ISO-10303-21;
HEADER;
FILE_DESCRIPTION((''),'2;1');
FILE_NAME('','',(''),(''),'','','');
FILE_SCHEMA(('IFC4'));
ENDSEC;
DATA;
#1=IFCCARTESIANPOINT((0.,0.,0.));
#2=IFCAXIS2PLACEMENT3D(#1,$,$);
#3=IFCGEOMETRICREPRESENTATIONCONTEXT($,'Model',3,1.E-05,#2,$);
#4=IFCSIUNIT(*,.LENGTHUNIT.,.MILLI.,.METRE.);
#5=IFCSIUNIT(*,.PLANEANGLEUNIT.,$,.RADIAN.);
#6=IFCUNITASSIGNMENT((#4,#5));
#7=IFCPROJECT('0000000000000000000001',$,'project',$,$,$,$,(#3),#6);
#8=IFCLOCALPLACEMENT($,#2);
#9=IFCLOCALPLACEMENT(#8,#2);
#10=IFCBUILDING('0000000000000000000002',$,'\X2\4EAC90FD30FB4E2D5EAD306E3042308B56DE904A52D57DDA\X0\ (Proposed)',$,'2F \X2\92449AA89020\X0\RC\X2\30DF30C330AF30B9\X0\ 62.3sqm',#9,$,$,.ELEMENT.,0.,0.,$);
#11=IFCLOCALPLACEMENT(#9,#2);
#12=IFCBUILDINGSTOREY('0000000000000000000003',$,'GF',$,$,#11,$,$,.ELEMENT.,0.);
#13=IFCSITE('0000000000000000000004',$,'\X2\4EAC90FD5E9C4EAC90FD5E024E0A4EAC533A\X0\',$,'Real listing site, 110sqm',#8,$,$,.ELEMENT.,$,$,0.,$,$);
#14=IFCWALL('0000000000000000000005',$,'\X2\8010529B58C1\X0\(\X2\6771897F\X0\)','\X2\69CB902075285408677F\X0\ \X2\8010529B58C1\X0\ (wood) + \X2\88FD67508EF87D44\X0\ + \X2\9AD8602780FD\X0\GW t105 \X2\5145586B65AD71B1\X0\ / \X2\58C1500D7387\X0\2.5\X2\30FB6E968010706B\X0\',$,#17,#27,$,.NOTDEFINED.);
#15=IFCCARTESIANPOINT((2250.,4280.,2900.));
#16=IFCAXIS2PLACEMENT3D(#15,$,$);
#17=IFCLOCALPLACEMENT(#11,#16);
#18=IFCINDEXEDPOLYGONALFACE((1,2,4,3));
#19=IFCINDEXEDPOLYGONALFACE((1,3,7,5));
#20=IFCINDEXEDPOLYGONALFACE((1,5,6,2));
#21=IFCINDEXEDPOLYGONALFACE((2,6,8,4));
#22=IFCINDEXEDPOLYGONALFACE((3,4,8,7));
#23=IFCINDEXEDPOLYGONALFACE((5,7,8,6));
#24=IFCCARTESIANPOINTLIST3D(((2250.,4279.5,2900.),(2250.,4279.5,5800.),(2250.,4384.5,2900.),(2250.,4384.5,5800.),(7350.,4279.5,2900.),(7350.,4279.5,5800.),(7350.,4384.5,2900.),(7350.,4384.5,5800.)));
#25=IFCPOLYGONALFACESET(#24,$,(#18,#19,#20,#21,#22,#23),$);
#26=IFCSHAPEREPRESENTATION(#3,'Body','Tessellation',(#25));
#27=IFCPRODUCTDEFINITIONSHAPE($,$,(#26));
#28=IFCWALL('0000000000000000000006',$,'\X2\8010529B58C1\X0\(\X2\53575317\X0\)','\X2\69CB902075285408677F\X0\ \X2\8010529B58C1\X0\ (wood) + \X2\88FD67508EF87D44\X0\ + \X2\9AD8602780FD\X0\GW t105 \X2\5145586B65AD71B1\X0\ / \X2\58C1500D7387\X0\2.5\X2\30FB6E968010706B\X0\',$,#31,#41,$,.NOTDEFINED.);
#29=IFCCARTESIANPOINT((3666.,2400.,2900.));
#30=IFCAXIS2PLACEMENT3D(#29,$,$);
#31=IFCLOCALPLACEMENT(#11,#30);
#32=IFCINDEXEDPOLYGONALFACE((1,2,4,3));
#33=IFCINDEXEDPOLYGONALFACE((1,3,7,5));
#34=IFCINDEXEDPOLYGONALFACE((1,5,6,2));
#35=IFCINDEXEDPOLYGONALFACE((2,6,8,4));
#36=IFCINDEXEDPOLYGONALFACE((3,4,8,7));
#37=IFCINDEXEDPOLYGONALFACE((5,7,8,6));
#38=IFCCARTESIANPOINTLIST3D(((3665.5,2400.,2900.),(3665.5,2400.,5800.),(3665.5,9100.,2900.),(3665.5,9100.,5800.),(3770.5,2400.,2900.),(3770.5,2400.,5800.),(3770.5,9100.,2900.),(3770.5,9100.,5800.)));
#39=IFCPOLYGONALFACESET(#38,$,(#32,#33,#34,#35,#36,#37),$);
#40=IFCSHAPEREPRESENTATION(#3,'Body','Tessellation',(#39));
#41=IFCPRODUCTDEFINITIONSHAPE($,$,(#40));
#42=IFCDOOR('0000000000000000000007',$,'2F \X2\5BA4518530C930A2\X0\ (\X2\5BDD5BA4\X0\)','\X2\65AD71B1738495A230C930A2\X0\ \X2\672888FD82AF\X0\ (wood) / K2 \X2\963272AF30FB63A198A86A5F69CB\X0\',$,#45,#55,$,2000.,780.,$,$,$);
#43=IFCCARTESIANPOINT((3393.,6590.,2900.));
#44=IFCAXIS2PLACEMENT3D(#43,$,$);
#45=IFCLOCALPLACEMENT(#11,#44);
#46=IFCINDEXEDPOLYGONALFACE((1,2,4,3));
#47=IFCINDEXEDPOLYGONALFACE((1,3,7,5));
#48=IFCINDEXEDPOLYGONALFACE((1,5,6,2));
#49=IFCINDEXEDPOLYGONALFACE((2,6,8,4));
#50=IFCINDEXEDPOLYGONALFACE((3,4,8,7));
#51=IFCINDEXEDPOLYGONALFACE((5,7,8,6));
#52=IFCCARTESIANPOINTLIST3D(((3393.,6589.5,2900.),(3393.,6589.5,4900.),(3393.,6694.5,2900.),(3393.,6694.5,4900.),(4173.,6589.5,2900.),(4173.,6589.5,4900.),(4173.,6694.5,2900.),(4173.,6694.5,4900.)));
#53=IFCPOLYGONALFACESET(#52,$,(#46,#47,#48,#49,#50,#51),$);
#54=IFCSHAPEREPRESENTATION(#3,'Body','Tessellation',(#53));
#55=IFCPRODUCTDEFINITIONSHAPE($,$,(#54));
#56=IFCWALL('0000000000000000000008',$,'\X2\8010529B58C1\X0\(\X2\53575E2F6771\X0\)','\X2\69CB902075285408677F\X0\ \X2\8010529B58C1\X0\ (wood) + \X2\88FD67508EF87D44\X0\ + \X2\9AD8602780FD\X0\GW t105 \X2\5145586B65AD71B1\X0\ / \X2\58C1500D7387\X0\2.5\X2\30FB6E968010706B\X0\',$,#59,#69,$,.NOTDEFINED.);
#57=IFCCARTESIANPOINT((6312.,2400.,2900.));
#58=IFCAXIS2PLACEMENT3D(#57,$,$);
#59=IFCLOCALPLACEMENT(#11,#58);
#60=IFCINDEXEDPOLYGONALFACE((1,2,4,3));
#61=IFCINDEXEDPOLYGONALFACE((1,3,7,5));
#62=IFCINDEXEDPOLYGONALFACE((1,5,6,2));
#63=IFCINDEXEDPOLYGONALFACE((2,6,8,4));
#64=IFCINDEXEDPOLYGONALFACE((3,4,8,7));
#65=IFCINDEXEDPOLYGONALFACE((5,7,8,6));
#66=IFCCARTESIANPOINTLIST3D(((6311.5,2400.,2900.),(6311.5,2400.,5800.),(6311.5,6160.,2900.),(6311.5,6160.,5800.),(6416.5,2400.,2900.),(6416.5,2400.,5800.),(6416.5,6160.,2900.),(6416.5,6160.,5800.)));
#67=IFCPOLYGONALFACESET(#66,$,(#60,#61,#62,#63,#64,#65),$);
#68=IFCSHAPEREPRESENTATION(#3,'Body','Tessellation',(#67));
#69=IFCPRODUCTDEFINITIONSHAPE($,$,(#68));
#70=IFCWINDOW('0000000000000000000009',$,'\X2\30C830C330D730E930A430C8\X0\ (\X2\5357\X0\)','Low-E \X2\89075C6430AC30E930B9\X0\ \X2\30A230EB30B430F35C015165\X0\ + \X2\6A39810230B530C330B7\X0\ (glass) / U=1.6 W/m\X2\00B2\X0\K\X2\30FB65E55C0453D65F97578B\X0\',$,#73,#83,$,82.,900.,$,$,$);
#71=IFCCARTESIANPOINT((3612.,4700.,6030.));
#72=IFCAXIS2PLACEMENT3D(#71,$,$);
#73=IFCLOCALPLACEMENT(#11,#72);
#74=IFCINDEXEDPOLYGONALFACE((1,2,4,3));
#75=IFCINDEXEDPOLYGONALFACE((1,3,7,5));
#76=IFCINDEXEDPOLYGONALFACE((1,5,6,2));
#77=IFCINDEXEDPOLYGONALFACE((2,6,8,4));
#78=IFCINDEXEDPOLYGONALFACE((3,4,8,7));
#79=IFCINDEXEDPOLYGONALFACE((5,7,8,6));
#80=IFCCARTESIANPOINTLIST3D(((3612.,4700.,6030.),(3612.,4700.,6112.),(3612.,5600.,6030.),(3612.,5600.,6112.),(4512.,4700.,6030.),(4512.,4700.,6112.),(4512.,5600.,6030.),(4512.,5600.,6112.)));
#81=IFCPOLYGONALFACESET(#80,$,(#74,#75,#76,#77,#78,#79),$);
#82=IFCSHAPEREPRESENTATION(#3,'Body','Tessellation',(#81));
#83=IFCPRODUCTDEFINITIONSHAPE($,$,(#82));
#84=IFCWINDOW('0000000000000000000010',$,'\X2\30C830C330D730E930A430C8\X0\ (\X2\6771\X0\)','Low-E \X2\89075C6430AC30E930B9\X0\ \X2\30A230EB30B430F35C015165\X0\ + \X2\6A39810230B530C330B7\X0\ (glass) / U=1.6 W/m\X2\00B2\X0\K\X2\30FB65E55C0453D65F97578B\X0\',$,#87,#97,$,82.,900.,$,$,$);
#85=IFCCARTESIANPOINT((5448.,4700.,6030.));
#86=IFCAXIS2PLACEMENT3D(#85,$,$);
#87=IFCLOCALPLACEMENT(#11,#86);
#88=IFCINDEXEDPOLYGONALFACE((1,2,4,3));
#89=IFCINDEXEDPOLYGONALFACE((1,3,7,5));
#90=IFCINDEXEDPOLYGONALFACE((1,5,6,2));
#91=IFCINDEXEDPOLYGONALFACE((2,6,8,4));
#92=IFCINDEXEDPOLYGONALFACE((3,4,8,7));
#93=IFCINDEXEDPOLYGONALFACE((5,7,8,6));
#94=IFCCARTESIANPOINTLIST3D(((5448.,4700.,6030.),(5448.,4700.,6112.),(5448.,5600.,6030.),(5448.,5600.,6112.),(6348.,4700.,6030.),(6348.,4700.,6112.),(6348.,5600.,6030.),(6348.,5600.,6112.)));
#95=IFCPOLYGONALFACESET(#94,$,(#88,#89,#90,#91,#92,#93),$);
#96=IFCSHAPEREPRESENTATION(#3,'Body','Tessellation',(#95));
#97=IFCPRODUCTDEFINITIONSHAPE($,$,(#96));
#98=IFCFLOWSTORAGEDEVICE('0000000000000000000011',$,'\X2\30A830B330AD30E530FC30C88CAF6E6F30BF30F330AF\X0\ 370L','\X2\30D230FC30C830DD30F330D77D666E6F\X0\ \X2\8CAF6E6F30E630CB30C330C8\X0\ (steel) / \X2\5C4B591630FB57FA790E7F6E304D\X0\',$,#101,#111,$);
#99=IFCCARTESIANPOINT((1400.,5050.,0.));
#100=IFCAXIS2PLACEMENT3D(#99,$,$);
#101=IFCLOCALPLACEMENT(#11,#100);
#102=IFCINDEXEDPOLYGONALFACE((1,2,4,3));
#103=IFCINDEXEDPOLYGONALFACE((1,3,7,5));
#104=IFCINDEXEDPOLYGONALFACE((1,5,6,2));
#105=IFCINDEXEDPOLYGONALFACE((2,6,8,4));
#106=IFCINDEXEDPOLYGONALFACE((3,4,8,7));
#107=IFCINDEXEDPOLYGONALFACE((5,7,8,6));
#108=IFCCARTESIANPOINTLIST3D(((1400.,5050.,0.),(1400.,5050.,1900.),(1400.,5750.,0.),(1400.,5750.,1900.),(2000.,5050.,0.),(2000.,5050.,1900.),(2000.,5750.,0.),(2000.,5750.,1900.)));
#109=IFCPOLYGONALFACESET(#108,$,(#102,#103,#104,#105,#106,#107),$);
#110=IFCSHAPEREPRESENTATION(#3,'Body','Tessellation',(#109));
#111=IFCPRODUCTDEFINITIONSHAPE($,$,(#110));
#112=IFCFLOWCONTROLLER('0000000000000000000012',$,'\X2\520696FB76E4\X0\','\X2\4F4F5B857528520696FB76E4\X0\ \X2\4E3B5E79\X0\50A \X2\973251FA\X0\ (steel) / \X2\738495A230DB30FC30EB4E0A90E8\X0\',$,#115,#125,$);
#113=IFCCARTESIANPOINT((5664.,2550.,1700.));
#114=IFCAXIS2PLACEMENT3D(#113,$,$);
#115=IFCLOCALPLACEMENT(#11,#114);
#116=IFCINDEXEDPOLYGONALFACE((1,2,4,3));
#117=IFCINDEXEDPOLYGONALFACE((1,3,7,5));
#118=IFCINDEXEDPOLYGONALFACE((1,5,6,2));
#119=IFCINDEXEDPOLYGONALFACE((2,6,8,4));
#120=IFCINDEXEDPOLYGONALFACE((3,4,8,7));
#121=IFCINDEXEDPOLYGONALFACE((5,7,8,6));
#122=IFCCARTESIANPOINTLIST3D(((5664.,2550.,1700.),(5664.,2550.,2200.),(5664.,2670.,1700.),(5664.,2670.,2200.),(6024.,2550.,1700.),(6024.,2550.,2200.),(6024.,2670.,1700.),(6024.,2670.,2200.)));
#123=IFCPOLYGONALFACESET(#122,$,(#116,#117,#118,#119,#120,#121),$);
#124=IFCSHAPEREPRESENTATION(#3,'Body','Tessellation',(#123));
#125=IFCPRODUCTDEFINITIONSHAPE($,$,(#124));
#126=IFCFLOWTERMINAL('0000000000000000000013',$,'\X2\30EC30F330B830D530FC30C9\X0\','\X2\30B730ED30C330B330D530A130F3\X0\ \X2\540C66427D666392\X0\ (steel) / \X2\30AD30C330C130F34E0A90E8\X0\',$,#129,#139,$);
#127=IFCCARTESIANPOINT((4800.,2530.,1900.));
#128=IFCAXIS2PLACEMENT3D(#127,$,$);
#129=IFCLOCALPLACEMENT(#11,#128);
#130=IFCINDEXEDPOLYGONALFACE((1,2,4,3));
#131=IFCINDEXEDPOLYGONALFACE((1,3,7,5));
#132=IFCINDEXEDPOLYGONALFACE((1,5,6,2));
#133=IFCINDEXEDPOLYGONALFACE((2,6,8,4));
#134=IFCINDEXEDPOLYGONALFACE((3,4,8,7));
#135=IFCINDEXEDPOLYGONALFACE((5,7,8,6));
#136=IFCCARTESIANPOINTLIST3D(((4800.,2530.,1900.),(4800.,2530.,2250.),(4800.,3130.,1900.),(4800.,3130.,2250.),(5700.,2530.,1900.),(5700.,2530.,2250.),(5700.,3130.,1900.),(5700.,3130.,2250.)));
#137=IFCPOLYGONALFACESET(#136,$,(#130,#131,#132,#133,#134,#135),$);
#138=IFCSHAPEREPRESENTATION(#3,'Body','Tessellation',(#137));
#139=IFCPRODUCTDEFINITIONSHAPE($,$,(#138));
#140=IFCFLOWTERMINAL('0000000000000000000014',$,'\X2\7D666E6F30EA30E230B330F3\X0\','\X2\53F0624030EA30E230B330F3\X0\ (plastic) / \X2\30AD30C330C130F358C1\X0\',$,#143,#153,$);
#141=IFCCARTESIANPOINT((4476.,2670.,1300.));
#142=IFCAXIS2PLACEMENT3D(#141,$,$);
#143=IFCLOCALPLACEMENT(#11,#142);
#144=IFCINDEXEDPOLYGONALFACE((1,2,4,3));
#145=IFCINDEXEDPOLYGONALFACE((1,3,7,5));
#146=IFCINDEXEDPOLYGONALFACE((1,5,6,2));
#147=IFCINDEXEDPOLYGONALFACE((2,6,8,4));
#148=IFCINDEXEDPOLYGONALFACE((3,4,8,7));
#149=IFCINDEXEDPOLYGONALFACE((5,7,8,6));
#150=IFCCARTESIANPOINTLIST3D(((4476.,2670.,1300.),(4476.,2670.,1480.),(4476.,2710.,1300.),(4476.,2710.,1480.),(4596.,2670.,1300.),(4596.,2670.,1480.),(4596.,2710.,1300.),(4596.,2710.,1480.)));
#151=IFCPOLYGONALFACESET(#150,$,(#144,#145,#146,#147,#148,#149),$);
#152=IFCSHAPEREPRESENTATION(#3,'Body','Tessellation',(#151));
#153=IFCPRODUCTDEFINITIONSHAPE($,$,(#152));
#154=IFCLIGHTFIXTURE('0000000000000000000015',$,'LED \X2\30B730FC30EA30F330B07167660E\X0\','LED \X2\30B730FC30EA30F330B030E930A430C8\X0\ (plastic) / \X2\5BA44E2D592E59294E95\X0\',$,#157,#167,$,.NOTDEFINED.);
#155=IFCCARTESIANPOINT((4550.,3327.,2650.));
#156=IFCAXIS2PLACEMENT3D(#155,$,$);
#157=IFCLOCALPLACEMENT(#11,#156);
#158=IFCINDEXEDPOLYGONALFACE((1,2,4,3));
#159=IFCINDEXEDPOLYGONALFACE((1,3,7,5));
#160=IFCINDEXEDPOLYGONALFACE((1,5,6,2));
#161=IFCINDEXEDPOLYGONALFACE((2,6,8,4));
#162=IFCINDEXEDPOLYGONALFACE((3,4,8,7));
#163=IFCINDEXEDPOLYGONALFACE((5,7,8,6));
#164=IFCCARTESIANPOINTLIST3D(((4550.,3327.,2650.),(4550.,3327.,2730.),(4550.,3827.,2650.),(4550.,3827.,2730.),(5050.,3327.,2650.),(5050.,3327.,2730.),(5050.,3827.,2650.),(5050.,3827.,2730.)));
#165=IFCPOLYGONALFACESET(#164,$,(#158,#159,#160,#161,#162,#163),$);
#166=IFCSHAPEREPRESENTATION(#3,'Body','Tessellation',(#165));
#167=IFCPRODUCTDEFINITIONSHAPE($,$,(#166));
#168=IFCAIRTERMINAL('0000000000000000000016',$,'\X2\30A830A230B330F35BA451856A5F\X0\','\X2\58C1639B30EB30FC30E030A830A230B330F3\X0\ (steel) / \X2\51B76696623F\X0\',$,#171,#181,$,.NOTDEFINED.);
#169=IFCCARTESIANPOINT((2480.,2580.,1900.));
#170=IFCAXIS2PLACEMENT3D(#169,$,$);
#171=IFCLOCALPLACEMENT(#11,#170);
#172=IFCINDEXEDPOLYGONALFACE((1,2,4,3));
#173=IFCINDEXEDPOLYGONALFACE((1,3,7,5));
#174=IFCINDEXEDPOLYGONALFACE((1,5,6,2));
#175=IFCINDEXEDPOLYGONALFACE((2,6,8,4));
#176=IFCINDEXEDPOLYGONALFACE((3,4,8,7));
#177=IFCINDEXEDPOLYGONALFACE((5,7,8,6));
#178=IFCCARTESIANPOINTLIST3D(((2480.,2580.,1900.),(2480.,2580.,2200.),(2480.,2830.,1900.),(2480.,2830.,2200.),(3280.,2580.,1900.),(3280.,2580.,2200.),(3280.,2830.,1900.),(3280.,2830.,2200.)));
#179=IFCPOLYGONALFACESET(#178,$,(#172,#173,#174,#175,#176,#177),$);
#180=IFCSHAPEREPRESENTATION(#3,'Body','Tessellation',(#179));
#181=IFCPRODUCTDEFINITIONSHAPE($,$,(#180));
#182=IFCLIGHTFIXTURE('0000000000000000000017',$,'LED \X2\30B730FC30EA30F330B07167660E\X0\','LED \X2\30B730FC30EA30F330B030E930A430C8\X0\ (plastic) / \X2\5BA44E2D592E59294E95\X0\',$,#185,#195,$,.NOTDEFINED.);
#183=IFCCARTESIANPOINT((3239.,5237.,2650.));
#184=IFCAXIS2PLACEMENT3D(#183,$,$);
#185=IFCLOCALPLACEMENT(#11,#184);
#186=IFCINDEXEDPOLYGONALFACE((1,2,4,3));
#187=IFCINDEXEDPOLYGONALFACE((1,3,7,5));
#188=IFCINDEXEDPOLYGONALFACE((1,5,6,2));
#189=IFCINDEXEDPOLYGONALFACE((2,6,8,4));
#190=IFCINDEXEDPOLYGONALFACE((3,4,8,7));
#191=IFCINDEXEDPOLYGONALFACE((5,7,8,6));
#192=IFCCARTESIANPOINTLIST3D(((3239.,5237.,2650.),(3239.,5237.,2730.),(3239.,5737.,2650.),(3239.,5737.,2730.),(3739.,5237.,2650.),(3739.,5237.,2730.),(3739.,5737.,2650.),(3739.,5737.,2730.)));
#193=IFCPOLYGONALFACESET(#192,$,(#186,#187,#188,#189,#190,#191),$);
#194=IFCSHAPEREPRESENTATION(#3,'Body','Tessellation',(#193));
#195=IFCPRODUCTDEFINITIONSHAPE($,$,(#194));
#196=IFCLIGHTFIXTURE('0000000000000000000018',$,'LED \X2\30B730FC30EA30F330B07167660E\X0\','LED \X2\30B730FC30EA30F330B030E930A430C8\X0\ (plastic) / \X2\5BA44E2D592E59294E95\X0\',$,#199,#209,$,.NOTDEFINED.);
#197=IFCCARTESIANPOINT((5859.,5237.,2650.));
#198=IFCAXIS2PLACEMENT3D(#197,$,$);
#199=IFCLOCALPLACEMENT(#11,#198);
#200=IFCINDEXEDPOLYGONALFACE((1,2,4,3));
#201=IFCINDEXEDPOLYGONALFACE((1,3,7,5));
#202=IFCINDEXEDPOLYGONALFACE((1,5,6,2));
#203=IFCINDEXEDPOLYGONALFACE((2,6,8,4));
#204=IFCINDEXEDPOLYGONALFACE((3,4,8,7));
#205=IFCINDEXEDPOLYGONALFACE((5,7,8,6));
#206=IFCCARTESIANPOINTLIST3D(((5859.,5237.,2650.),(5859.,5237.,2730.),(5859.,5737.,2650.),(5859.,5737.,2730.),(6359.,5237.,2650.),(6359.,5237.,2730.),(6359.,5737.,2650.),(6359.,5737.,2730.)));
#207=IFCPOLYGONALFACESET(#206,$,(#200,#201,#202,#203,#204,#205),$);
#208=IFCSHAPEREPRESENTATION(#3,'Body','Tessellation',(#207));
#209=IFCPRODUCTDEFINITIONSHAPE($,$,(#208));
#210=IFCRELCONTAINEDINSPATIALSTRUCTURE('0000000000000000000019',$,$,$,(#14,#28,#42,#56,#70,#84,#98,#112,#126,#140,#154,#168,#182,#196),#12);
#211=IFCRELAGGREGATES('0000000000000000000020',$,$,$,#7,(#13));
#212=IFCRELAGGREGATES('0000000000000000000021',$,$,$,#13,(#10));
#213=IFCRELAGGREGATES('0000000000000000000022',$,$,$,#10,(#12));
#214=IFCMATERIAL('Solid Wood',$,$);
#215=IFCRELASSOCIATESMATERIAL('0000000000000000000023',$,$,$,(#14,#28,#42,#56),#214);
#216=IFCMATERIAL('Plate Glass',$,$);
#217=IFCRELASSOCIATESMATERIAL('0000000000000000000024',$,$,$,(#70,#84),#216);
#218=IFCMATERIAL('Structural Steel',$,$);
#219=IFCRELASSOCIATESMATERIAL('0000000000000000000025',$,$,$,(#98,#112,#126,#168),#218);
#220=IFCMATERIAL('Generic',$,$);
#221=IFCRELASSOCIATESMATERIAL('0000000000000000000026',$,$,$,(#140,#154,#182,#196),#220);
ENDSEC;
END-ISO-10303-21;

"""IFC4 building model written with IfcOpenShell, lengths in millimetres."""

from ifc_helpers import new_model, si_unit, frame, frame_2d, origin, place, context, project, spatial, rectangle, extrude, material, element, fill, save


model = new_model("IFC4")

# Units and contexts
model_context = context("Model", 3, precision=1e-05, world=origin())
ifc_project = project(units=[si_unit("LENGTHUNIT", "METRE", prefix="MILLI"), si_unit("PLANEANGLEUNIT", "RADIAN")], contexts=[model_context])

# Site, building, storey
site_placement = place(None, origin())
site = spatial("IfcSite", under=ifc_project, at=site_placement, Name="京都府京都市上京区", ObjectType="Real listing site, 110sqm", CompositionType="ELEMENT", RefElevation=0.0)
building_placement = place(site_placement, origin())
building = spatial("IfcBuilding", under=site, at=building_placement, Name="京都・中庭のある回遊動線 (Proposed)", ObjectType="2F 鉄骨造RCミックス 62.3sqm", CompositionType="ELEMENT", ElevationOfRefHeight=0.0, ElevationOfTerrain=0.0)
storey_placement = place(building_placement, origin())
storey = spatial("IfcBuildingStorey", under=building, at=storey_placement, Name="GF", CompositionType="ELEMENT", Elevation=0.0)

# Shared definitions
ifc_material_1 = material(Name="Solid Wood")

# Wall
wall_1_placement = place(storey_placement, frame((2250.0, 4280.0, 2900.0)))
element("IfcWall", 1, at=wall_1_placement, inside=storey, material=ifc_material_1, Name="耐力壁(東西)", Description="構造用合板 耐力壁 (wood) + 製材軸組 + 高性能GW t105 充填断熱 / 壁倍率2.5・準耐火", PredefinedType="NOTDEFINED", context=model_context, shape_type="SweptSolid", body=[
    extrude(rectangle(XDim=5100.0, YDim=105.0, at=frame_2d((2550.0, 52.0))), frame((2250.0, 4280.0, 2900.0)), (0.0, 0.0, 1.0), 2900.0),
])

# Wall, opening, door
wall_2_placement = place(storey_placement, frame((3666.0, 2400.0, 2900.0)))
wall_2 = element("IfcWall", 2, at=wall_2_placement, inside=storey, material=ifc_material_1, Name="耐力壁(南北)", Description="構造用合板 耐力壁 (wood) + 製材軸組 + 高性能GW t105 充填断熱 / 壁倍率2.5・準耐火", PredefinedType="NOTDEFINED", context=model_context, shape_type="SweptSolid", body=[
    extrude(rectangle(XDim=105.0, YDim=6700.0, at=frame_2d((52.0, 3350.0))), frame((3666.0, 2400.0, 2900.0)), (0.0, 0.0, 1.0), 2900.0),
])
opening_placement = place(storey_placement, frame((3393.0, 6590.0, 2900.0)))
opening = element("IfcOpeningElement", 3, at=opening_placement, cuts=wall_2, PredefinedType="NOTDEFINED", context=model_context, shape_type="SweptSolid", body=[
    extrude(rectangle(XDim=780.0, YDim=105.0, at=frame_2d((390.0, 52.0))), frame((3393.0, 6590.0, 2900.0)), (0.0, 0.0, 1.0), 2000.0),
])
door_placement = place(storey_placement, frame((3393.0, 6590.0, 2900.0)))
door = element("IfcDoor", 4, at=door_placement, inside=storey, material=ifc_material_1, Name="2F 室内ドア (寝室)", Description="断熱玄関ドア 木製芯 (wood) / K2 防犯・採風機構", OverallHeight=2000.0, OverallWidth=780.0, context=model_context, shape_type="SweptSolid", body=[
    extrude(rectangle(XDim=780.0, YDim=105.0, at=frame_2d((390.0, 52.0))), frame((3393.0, 6590.0, 2900.0)), (0.0, 0.0, 1.0), 2000.0),
])
fill(opening, door)

# Wall
wall_3_placement = place(storey_placement, frame((6312.0, 2400.0, 2900.0)))
element("IfcWall", 5, at=wall_3_placement, inside=storey, material=ifc_material_1, Name="耐力壁(南帯東)", Description="構造用合板 耐力壁 (wood) + 製材軸組 + 高性能GW t105 充填断熱 / 壁倍率2.5・準耐火", PredefinedType="NOTDEFINED", context=model_context, shape_type="SweptSolid", body=[
    extrude(rectangle(XDim=105.0, YDim=3760.0, at=frame_2d((52.0, 1880.0))), frame((6312.0, 2400.0, 2900.0)), (0.0, 0.0, 1.0), 2900.0),
])

# Windows
ifc_material_2 = material(Name="Plate Glass")
window_1_placement = place(storey_placement, frame((3612.0, 4700.0, 6030.0)))
element("IfcWindow", 6, at=window_1_placement, inside=storey, material=ifc_material_2, Name="トップライト (南)", Description="Low-E 複層ガラス アルゴン封入 + 樹脂サッシ (glass) / U=1.6 W/m²K・日射取得型", OverallHeight=82.0, OverallWidth=900.0, context=model_context, shape_type="SweptSolid", body=[
    extrude(rectangle(XDim=900.0, YDim=900.0, at=frame_2d((450.0, 450.0))), frame((3612.0, 4700.0, 6030.0)), (0.0, 0.0, 1.0), 82.0),
])
window_2_placement = place(storey_placement, frame((5448.0, 4700.0, 6030.0)))
element("IfcWindow", 7, at=window_2_placement, inside=storey, material=ifc_material_2, Name="トップライト (東)", Description="Low-E 複層ガラス アルゴン封入 + 樹脂サッシ (glass) / U=1.6 W/m²K・日射取得型", OverallHeight=82.0, OverallWidth=900.0, context=model_context, shape_type="SweptSolid", body=[
    extrude(rectangle(XDim=900.0, YDim=900.0, at=frame_2d((450.0, 450.0))), frame((5448.0, 4700.0, 6030.0)), (0.0, 0.0, 1.0), 82.0),
])

# Flow storage device
ifc_material_3 = material(Name="Structural Steel")
flow_storage_device_placement = place(storey_placement, frame((1400.0, 5050.0, 0.0)))
element("IfcFlowStorageDevice", 8, at=flow_storage_device_placement, inside=storey, material=ifc_material_3, Name="エコキュート貯湯タンク 370L", Description="ヒートポンプ給湯 貯湯ユニット (steel) / 屋外・基礎置き", context=model_context, shape_type="SweptSolid", body=[
    extrude(rectangle(XDim=600.0, YDim=700.0, at=frame_2d((300.0, 350.0))), frame((1400.0, 5050.0, 0.0)), (0.0, 0.0, 1.0), 1900.0),
])

# Flow controller
flow_controller_placement = place(storey_placement, frame((5664.0, 2550.0, 1700.0)))
element("IfcFlowController", 9, at=flow_controller_placement, inside=storey, material=ifc_material_3, Name="分電盤", Description="住宅用分電盤 主幹50A 露出 (steel) / 玄関ホール上部", context=model_context, shape_type="SweptSolid", body=[
    extrude(rectangle(XDim=360.0, YDim=120.0, at=frame_2d((180.0, 60.0))), frame((5664.0, 2550.0, 1700.0)), (0.0, 0.0, 1.0), 500.0),
])

# Flow terminals
flow_terminal_1_placement = place(storey_placement, frame((4800.0, 2530.0, 1900.0)))
element("IfcFlowTerminal", 10, at=flow_terminal_1_placement, inside=storey, material=ifc_material_3, Name="レンジフード", Description="シロッコファン 同時給排 (steel) / キッチン上部", context=model_context, shape_type="SweptSolid", body=[
    extrude(rectangle(XDim=900.0, YDim=600.0, at=frame_2d((450.0, 300.0))), frame((4800.0, 2530.0, 1900.0)), (0.0, 0.0, 1.0), 350.0),
])
ifc_material_4 = material(Name="Generic")
flow_terminal_2_placement = place(storey_placement, frame((4476.0, 2670.0, 1300.0)))
element("IfcFlowTerminal", 11, at=flow_terminal_2_placement, inside=storey, material=ifc_material_4, Name="給湯リモコン", Description="台所リモコン (plastic) / キッチン壁", context=model_context, shape_type="SweptSolid", body=[
    extrude(rectangle(XDim=120.0, YDim=40.0, at=frame_2d((60.0, 20.0))), frame((4476.0, 2670.0, 1300.0)), (0.0, 0.0, 1.0), 180.0),
])

# Light fixture
light_fixture_1_placement = place(storey_placement, frame((4550.0, 3327.0, 2650.0)))
element("IfcLightFixture", 12, at=light_fixture_1_placement, inside=storey, material=ifc_material_4, Name="LED シーリング照明", Description="LED シーリングライト (plastic) / 室中央天井", PredefinedType="NOTDEFINED", context=model_context, shape_type="SweptSolid", body=[
    extrude(rectangle(XDim=500.0, YDim=500.0, at=frame_2d((250.0, 250.0))), frame((4550.0, 3327.0, 2650.0)), (0.0, 0.0, 1.0), 80.0),
])

# Air terminal
air_terminal_1_placement = place(storey_placement, frame((2480.0, 2580.0, 1900.0)))
element("IfcAirTerminal", 13, at=air_terminal_1_placement, inside=storey, material=ifc_material_3, Name="エアコン室内機", Description="壁掛ルームエアコン (steel) / 冷暖房", PredefinedType="NOTDEFINED", context=model_context, shape_type="SweptSolid", body=[
    extrude(rectangle(XDim=800.0, YDim=250.0, at=frame_2d((400.0, 125.0))), frame((2480.0, 2580.0, 1900.0)), (0.0, 0.0, 1.0), 300.0),
])

# Light fixtures
light_fixture_2_placement = place(storey_placement, frame((3239.0, 5237.0, 2650.0)))
element("IfcLightFixture", 14, at=light_fixture_2_placement, inside=storey, material=ifc_material_4, Name="LED シーリング照明", Description="LED シーリングライト (plastic) / 室中央天井", PredefinedType="NOTDEFINED", context=model_context, shape_type="SweptSolid", body=[
    extrude(rectangle(XDim=500.0, YDim=500.0, at=frame_2d((250.0, 250.0))), frame((3239.0, 5237.0, 2650.0)), (0.0, 0.0, 1.0), 80.0),
])
light_fixture_3_placement = place(storey_placement, frame((5859.0, 5237.0, 2650.0)))
element("IfcLightFixture", 15, at=light_fixture_3_placement, inside=storey, material=ifc_material_4, Name="LED シーリング照明", Description="LED シーリングライト (plastic) / 室中央天井", PredefinedType="NOTDEFINED", context=model_context, shape_type="SweptSolid", body=[
    extrude(rectangle(XDim=500.0, YDim=500.0, at=frame_2d((250.0, 250.0))), frame((5859.0, 5237.0, 2650.0)), (0.0, 0.0, 1.0), 80.0),
])

save(model, "model.ifc")
